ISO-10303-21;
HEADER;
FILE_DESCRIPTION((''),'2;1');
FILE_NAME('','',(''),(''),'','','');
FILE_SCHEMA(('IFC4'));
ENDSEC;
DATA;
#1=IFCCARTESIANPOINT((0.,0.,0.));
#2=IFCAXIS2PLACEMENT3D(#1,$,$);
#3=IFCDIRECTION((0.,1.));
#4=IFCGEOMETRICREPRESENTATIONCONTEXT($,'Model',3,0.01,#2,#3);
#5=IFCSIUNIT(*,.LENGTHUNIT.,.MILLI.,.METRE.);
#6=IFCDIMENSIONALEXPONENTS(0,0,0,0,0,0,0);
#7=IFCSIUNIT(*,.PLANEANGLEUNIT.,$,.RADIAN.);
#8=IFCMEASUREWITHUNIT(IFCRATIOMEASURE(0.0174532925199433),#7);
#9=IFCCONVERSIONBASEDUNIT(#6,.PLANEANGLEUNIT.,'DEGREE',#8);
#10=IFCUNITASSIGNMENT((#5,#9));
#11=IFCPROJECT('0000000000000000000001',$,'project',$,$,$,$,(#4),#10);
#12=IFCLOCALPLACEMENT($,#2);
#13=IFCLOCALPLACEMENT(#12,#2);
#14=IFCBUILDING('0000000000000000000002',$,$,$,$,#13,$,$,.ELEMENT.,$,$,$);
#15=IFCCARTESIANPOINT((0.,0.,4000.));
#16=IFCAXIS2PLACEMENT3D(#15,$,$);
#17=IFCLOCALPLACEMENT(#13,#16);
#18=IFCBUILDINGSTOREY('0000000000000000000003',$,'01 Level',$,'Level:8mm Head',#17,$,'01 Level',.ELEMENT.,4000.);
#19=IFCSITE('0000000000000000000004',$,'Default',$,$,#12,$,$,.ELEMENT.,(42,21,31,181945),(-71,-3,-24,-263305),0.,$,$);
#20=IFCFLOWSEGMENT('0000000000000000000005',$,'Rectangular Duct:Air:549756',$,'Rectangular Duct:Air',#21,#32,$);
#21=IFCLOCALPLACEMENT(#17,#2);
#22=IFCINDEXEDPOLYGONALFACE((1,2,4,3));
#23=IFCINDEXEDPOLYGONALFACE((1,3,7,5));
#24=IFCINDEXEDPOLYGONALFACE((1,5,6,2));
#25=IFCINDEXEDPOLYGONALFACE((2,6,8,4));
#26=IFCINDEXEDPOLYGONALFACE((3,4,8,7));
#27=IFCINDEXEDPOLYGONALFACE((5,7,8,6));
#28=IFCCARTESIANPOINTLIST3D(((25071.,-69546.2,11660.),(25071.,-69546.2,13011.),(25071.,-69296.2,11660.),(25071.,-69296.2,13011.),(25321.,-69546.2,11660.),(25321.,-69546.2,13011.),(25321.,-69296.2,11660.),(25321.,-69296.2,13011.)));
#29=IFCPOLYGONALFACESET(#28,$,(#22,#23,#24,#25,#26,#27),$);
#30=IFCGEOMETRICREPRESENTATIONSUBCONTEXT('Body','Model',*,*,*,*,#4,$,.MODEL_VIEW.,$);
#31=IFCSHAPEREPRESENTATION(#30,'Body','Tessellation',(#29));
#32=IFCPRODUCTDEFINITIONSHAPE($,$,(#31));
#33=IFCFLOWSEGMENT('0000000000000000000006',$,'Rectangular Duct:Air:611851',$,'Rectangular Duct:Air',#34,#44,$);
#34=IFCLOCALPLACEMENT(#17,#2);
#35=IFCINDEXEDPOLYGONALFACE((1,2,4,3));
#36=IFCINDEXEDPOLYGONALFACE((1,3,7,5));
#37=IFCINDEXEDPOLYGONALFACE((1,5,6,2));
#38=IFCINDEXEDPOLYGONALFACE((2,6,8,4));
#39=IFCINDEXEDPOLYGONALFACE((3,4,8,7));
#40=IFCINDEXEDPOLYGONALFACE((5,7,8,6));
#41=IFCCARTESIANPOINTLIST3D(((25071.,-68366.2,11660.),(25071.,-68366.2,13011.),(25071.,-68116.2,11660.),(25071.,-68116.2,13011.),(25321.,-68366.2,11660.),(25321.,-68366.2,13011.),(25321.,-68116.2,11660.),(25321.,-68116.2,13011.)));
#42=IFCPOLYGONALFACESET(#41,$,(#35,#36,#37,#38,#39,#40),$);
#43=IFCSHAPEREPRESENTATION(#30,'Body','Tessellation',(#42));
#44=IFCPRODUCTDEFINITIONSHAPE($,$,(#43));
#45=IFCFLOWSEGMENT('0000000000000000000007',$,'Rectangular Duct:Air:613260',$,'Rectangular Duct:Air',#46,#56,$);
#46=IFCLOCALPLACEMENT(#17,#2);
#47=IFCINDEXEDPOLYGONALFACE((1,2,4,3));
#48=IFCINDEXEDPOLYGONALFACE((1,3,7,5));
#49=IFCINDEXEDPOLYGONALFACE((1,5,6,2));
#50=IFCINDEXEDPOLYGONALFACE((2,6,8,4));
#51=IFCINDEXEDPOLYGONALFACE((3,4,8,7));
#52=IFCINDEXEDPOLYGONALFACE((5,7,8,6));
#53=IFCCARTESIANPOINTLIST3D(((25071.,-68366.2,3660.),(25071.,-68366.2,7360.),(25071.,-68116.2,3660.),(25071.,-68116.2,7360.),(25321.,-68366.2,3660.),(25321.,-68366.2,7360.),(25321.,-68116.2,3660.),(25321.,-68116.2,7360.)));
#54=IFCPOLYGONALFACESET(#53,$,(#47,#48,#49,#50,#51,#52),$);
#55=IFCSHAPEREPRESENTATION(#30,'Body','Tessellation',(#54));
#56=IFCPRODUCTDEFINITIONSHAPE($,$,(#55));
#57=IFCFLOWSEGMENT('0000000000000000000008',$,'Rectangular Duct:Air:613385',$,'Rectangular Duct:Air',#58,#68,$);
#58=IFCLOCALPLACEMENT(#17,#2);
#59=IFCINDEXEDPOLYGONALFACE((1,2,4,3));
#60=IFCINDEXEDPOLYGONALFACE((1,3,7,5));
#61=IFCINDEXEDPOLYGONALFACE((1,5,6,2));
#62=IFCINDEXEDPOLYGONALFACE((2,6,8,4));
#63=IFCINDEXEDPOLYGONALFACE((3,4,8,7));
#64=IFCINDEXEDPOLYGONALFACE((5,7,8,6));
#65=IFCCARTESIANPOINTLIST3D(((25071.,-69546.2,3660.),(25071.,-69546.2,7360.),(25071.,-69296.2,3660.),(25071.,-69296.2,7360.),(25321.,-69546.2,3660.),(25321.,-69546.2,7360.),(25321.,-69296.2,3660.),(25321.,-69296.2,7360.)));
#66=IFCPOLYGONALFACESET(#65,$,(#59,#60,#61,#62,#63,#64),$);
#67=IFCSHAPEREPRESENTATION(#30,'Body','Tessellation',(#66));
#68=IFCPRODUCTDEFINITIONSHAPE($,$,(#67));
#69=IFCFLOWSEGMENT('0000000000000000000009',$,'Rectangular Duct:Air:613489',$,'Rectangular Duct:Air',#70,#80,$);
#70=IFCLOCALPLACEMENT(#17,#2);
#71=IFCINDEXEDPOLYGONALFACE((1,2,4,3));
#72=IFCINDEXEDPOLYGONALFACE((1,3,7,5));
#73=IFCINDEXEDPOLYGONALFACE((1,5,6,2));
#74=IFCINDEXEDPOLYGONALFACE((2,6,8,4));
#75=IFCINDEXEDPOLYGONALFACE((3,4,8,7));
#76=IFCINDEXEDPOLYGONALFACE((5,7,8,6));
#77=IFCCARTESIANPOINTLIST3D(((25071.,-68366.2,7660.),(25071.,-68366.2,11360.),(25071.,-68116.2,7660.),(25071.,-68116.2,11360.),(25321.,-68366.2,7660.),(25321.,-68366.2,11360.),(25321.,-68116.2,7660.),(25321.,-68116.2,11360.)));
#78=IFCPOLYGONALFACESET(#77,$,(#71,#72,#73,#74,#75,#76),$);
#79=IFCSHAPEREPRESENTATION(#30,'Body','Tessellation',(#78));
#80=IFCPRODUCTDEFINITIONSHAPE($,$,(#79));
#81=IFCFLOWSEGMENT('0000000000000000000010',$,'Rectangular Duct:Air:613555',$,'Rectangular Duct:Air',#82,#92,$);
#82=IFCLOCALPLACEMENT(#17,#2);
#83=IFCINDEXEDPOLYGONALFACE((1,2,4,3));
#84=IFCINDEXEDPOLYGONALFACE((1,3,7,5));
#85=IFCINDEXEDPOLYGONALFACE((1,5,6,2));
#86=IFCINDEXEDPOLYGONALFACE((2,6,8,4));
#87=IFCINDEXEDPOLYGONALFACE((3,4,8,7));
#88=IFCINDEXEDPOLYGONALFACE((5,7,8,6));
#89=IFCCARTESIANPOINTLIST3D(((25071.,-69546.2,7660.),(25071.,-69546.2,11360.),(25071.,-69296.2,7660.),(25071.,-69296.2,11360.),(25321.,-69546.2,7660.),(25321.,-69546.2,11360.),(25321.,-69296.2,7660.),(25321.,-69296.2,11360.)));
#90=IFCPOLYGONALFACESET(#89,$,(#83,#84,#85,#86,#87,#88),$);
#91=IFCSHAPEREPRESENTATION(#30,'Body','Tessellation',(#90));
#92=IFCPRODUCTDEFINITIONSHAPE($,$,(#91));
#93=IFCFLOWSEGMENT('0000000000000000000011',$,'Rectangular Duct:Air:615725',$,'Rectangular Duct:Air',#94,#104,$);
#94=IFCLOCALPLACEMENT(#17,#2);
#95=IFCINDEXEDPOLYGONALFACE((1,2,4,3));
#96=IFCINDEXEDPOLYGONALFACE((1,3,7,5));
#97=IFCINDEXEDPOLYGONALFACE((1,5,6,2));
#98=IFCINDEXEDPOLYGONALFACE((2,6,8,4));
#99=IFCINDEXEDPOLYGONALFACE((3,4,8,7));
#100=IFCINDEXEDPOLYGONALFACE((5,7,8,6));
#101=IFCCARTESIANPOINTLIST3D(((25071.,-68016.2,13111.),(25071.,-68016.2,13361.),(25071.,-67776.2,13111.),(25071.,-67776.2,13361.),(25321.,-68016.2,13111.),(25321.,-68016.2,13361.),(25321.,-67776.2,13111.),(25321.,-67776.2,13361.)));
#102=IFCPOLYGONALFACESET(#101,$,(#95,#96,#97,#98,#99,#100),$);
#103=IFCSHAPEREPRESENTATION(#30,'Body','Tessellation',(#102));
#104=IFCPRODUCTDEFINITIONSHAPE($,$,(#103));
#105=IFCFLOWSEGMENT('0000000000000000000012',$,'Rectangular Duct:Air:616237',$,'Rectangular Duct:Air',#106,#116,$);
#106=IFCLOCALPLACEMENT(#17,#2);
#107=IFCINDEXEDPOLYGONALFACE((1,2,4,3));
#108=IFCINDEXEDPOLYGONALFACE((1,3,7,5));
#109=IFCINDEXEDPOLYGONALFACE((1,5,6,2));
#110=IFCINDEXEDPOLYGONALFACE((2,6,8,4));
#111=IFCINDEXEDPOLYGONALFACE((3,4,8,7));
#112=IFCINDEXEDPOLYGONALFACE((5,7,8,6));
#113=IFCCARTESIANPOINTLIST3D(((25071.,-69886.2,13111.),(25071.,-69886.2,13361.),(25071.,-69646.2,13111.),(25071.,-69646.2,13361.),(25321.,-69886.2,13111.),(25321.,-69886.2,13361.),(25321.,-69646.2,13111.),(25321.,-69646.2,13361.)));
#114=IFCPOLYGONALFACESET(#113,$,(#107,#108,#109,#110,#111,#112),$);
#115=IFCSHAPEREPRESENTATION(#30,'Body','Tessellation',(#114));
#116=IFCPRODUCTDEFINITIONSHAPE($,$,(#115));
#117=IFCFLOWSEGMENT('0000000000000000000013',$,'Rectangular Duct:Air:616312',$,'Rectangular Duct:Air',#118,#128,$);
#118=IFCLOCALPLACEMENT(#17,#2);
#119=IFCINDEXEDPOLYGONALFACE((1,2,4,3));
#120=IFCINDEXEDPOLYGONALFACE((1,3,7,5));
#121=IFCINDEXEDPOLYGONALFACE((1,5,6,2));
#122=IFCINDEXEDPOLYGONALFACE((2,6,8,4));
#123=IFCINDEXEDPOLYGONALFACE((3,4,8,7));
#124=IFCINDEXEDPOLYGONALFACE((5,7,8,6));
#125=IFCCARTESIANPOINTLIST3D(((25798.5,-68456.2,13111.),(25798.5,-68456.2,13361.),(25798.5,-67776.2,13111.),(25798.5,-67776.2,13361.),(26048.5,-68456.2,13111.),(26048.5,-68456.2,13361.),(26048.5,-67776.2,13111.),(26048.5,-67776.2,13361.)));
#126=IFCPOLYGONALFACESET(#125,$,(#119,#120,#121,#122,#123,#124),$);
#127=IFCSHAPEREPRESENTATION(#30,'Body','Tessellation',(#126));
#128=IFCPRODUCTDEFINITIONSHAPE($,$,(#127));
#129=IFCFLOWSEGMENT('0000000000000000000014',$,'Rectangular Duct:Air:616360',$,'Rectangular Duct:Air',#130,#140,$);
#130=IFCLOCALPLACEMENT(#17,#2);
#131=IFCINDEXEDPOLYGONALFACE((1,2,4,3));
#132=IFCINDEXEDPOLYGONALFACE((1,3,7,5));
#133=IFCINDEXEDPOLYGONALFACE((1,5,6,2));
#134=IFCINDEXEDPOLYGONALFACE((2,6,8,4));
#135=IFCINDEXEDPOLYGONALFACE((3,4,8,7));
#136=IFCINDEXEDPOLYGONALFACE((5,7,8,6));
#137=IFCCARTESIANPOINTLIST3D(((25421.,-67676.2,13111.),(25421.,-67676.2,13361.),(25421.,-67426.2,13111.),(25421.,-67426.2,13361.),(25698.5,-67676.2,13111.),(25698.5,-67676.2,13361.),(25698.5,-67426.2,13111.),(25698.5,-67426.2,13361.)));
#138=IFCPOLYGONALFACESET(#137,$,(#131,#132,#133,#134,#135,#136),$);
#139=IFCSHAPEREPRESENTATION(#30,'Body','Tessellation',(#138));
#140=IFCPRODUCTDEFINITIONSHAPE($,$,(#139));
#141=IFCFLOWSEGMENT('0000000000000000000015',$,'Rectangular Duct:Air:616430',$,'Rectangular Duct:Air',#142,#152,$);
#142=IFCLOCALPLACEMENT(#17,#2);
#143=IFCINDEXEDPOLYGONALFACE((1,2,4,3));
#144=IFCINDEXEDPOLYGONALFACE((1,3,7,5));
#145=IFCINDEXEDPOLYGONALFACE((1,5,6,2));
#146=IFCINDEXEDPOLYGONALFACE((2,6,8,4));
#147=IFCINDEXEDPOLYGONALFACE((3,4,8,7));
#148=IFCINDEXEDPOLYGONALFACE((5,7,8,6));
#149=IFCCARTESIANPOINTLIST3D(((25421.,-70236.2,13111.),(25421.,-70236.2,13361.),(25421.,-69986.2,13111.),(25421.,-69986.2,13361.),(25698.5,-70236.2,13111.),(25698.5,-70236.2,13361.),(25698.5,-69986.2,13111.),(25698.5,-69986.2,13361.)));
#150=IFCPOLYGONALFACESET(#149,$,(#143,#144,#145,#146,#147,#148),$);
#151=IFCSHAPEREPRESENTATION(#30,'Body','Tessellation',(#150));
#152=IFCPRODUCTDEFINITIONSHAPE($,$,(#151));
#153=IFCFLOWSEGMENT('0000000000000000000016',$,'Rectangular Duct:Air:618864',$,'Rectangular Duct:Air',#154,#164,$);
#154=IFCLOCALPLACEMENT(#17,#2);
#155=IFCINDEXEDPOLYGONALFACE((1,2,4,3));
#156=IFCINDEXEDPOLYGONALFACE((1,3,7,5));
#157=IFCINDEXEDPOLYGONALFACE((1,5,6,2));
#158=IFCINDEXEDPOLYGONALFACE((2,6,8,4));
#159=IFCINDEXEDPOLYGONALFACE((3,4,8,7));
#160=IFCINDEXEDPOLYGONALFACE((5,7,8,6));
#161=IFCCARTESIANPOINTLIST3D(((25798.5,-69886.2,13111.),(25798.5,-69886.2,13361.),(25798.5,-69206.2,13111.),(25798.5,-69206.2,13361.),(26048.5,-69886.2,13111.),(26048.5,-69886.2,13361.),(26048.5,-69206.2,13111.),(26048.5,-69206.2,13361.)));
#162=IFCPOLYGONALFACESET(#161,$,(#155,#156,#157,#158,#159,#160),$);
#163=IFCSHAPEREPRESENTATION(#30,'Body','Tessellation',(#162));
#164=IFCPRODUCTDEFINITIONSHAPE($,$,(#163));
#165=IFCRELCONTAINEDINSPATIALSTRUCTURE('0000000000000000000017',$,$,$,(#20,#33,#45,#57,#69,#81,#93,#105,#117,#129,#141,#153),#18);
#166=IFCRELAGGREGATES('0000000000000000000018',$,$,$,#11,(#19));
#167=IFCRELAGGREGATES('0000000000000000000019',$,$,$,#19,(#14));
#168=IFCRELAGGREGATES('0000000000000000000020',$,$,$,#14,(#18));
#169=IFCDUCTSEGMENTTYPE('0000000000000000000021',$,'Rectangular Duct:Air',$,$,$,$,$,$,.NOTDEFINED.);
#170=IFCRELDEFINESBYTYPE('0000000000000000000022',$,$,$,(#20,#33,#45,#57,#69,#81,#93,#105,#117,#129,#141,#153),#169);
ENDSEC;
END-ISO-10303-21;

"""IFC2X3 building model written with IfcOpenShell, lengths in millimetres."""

from ifc_helpers import new_model, entity, si_unit, converted_unit, direction, frame, frame_2d, origin, place, context, subcontext, project, spatial, rectangle, extrude, type_object, element, save


model = new_model("IFC2X3")

# Units and contexts
model_context = context("Model", 3, precision=0.01, world=origin(), true_north=direction((0.0, 1.0)))
body_context = subcontext(model_context, "Body", "Model", "MODEL_VIEW")
ifc_project = project(units=[si_unit("LENGTHUNIT", "METRE", prefix="MILLI"), converted_unit("PLANEANGLEUNIT", "DEGREE", entity("IfcRatioMeasure", 0.0174532925199433), si_unit("PLANEANGLEUNIT", "RADIAN"), dimensions=[0, 0, 0, 0, 0, 0, 0])], contexts=[model_context])

# Site, building, storey
site_placement = place(None, origin())
site = spatial("IfcSite", under=ifc_project, at=site_placement, Name="Default", CompositionType="ELEMENT", RefLatitude=(42, 21, 31, 181945), RefLongitude=(-71, -3, -24, -263305), RefElevation=0.0)
building_placement = place(site_placement, origin())
building = spatial("IfcBuilding", under=site, at=building_placement, CompositionType="ELEMENT")
storey_placement = place(building_placement, frame((0.0, 0.0, 4000.0)))
storey = spatial("IfcBuildingStorey", under=building, at=storey_placement, Name="01 Level", ObjectType="Level:8mm Head", LongName="01 Level", CompositionType="ELEMENT", Elevation=4000.0)

# Flow segments
duct_segment_type_1 = type_object("IfcDuctSegmentType", Name="Rectangular Duct:Air", PredefinedType="NOTDEFINED")
flow_segment_1_placement = place(storey_placement, frame((25071.0, -69546.2, 11660.0)))
element("IfcFlowSegment", 1, at=flow_segment_1_placement, inside=storey, type_object=duct_segment_type_1, Name="Rectangular Duct:Air:549756", ObjectType="Rectangular Duct:Air", context=body_context, shape_type="SweptSolid", body=[
    extrude(rectangle(XDim=250.0, YDim=250.0, at=frame_2d((0.0, 0.0), x_axis=(1.0, 0.0))), frame((125.0, 125.0, 0.0), z_axis=(0.0, 0.0, 1.0), x_axis=(-1.0, 0.0, 0.0)), (0.0, 0.0, 1.0), 1351.0),
])
flow_segment_2_placement = place(storey_placement, frame((25071.0, -68366.2, 11660.0)))
element("IfcFlowSegment", 2, at=flow_segment_2_placement, inside=storey, type_object=duct_segment_type_1, Name="Rectangular Duct:Air:611851", ObjectType="Rectangular Duct:Air", context=body_context, shape_type="SweptSolid", body=[
    extrude(rectangle(XDim=250.0, YDim=250.0, at=frame_2d((0.0, 0.0), x_axis=(1.0, 0.0))), frame((125.0, 125.0, 0.0), z_axis=(0.0, 0.0, 1.0), x_axis=(0.0, -1.0, 0.0)), (0.0, 0.0, 1.0), 1351.0),
])
flow_segment_3_placement = place(storey_placement, frame((25071.0, -68366.2, 3660.0)))
element("IfcFlowSegment", 3, at=flow_segment_3_placement, inside=storey, type_object=duct_segment_type_1, Name="Rectangular Duct:Air:613260", ObjectType="Rectangular Duct:Air", context=body_context, shape_type="SweptSolid", body=[
    extrude(rectangle(XDim=250.0, YDim=250.0, at=frame_2d((0.0, 0.0), x_axis=(1.0, 0.0))), frame((125.0, 125.0, 0.0)), (0.0, 0.0, 1.0), 3700.0),
])
flow_segment_4_placement = place(storey_placement, frame((25071.0, -69546.2, 3660.0)))
element("IfcFlowSegment", 4, at=flow_segment_4_placement, inside=storey, type_object=duct_segment_type_1, Name="Rectangular Duct:Air:613385", ObjectType="Rectangular Duct:Air", context=body_context, shape_type="SweptSolid", body=[
    extrude(rectangle(XDim=250.0, YDim=250.0, at=frame_2d((0.0, 0.0), x_axis=(1.0, 0.0))), frame((125.0, 125.0, 0.0), z_axis=(0.0, 0.0, 1.0), x_axis=(0.0, -1.0, 0.0)), (0.0, 0.0, 1.0), 3700.0),
])
flow_segment_5_placement = place(storey_placement, frame((25071.0, -68366.2, 7660.0)))
element("IfcFlowSegment", 5, at=flow_segment_5_placement, inside=storey, type_object=duct_segment_type_1, Name="Rectangular Duct:Air:613489", ObjectType="Rectangular Duct:Air", context=body_context, shape_type="SweptSolid", body=[
    extrude(rectangle(XDim=250.0, YDim=250.0, at=frame_2d((0.0, 0.0), x_axis=(1.0, 0.0))), frame((125.0, 125.0, 0.0), z_axis=(0.0, 0.0, 1.0), x_axis=(0.0, -1.0, 0.0)), (0.0, 0.0, 1.0), 3700.0),
])
flow_segment_6_placement = place(storey_placement, frame((25071.0, -69546.2, 7660.0)))
element("IfcFlowSegment", 6, at=flow_segment_6_placement, inside=storey, type_object=duct_segment_type_1, Name="Rectangular Duct:Air:613555", ObjectType="Rectangular Duct:Air", context=body_context, shape_type="SweptSolid", body=[
    extrude(rectangle(XDim=250.0, YDim=250.0, at=frame_2d((0.0, 0.0), x_axis=(1.0, 0.0))), frame((125.0, 125.0, 0.0), z_axis=(0.0, 0.0, 1.0), x_axis=(0.0, -1.0, 0.0)), (0.0, 0.0, 1.0), 3700.0),
])
flow_segment_7_placement = place(storey_placement, frame((25071.0, -68016.2, 13111.0)))
element("IfcFlowSegment", 7, at=flow_segment_7_placement, inside=storey, type_object=duct_segment_type_1, Name="Rectangular Duct:Air:615725", ObjectType="Rectangular Duct:Air", context=body_context, shape_type="SweptSolid", body=[
    extrude(rectangle(XDim=240.0, YDim=250.0, at=frame_2d((0.0, 0.0), x_axis=(1.0, 0.0))), frame((125.0, 120.0, 0.0), z_axis=(0.0, 0.0, 1.0), x_axis=(0.0, 1.0, 0.0)), (0.0, 0.0, 1.0), 250.0),
])
flow_segment_8_placement = place(storey_placement, frame((25071.0, -69886.2, 13111.0)))
element("IfcFlowSegment", 8, at=flow_segment_8_placement, inside=storey, type_object=duct_segment_type_1, Name="Rectangular Duct:Air:616237", ObjectType="Rectangular Duct:Air", context=body_context, shape_type="SweptSolid", body=[
    extrude(rectangle(XDim=240.0, YDim=250.0, at=frame_2d((0.0, 0.0), x_axis=(1.0, 0.0))), frame((125.0, 120.0, 0.0), z_axis=(0.0, 0.0, 1.0), x_axis=(0.0, 1.0, 0.0)), (0.0, 0.0, 1.0), 250.0),
])
flow_segment_9_placement = place(storey_placement, frame((25798.5, -68456.2, 13111.0)))
element("IfcFlowSegment", 9, at=flow_segment_9_placement, inside=storey, type_object=duct_segment_type_1, Name="Rectangular Duct:Air:616312", ObjectType="Rectangular Duct:Air", context=body_context, shape_type="SweptSolid", body=[
    extrude(rectangle(XDim=680.0, YDim=250.0, at=frame_2d((0.0, 0.0), x_axis=(1.0, 0.0))), frame((125.0, 340.0, 0.0), z_axis=(0.0, 0.0, 1.0), x_axis=(0.0, 1.0, 0.0)), (0.0, 0.0, 1.0), 250.0),
])
flow_segment_10_placement = place(storey_placement, frame((25421.0, -67676.2, 13111.0)))
element("IfcFlowSegment", 10, at=flow_segment_10_placement, inside=storey, type_object=duct_segment_type_1, Name="Rectangular Duct:Air:616360", ObjectType="Rectangular Duct:Air", context=body_context, shape_type="SweptSolid", body=[
    extrude(rectangle(XDim=277.5, YDim=250.0, at=frame_2d((0.0, 0.0), x_axis=(1.0, 0.0))), frame((138.8, 125.0, 0.0)), (0.0, 0.0, 1.0), 250.0),
])
flow_segment_11_placement = place(storey_placement, frame((25421.0, -70236.2, 13111.0)))
element("IfcFlowSegment", 11, at=flow_segment_11_placement, inside=storey, type_object=duct_segment_type_1, Name="Rectangular Duct:Air:616430", ObjectType="Rectangular Duct:Air", context=body_context, shape_type="SweptSolid", body=[
    extrude(rectangle(XDim=277.5, YDim=250.0, at=frame_2d((0.0, 0.0), x_axis=(1.0, 0.0))), frame((138.8, 125.0, 0.0), z_axis=(0.0, 0.0, 1.0), x_axis=(-1.0, 0.0, 0.0)), (0.0, 0.0, 1.0), 250.0),
])
flow_segment_12_placement = place(storey_placement, frame((25798.5, -69886.2, 13111.0)))
element("IfcFlowSegment", 12, at=flow_segment_12_placement, inside=storey, type_object=duct_segment_type_1, Name="Rectangular Duct:Air:618864", ObjectType="Rectangular Duct:Air", context=body_context, shape_type="SweptSolid", body=[
    extrude(rectangle(XDim=680.0, YDim=250.0, at=frame_2d((0.0, 0.0), x_axis=(1.0, 0.0))), frame((125.0, 340.0, 0.0), z_axis=(0.0, 0.0, 1.0), x_axis=(0.0, 1.0, 0.0)), (0.0, 0.0, 1.0), 250.0),
])

save(model, "model.ifc")
